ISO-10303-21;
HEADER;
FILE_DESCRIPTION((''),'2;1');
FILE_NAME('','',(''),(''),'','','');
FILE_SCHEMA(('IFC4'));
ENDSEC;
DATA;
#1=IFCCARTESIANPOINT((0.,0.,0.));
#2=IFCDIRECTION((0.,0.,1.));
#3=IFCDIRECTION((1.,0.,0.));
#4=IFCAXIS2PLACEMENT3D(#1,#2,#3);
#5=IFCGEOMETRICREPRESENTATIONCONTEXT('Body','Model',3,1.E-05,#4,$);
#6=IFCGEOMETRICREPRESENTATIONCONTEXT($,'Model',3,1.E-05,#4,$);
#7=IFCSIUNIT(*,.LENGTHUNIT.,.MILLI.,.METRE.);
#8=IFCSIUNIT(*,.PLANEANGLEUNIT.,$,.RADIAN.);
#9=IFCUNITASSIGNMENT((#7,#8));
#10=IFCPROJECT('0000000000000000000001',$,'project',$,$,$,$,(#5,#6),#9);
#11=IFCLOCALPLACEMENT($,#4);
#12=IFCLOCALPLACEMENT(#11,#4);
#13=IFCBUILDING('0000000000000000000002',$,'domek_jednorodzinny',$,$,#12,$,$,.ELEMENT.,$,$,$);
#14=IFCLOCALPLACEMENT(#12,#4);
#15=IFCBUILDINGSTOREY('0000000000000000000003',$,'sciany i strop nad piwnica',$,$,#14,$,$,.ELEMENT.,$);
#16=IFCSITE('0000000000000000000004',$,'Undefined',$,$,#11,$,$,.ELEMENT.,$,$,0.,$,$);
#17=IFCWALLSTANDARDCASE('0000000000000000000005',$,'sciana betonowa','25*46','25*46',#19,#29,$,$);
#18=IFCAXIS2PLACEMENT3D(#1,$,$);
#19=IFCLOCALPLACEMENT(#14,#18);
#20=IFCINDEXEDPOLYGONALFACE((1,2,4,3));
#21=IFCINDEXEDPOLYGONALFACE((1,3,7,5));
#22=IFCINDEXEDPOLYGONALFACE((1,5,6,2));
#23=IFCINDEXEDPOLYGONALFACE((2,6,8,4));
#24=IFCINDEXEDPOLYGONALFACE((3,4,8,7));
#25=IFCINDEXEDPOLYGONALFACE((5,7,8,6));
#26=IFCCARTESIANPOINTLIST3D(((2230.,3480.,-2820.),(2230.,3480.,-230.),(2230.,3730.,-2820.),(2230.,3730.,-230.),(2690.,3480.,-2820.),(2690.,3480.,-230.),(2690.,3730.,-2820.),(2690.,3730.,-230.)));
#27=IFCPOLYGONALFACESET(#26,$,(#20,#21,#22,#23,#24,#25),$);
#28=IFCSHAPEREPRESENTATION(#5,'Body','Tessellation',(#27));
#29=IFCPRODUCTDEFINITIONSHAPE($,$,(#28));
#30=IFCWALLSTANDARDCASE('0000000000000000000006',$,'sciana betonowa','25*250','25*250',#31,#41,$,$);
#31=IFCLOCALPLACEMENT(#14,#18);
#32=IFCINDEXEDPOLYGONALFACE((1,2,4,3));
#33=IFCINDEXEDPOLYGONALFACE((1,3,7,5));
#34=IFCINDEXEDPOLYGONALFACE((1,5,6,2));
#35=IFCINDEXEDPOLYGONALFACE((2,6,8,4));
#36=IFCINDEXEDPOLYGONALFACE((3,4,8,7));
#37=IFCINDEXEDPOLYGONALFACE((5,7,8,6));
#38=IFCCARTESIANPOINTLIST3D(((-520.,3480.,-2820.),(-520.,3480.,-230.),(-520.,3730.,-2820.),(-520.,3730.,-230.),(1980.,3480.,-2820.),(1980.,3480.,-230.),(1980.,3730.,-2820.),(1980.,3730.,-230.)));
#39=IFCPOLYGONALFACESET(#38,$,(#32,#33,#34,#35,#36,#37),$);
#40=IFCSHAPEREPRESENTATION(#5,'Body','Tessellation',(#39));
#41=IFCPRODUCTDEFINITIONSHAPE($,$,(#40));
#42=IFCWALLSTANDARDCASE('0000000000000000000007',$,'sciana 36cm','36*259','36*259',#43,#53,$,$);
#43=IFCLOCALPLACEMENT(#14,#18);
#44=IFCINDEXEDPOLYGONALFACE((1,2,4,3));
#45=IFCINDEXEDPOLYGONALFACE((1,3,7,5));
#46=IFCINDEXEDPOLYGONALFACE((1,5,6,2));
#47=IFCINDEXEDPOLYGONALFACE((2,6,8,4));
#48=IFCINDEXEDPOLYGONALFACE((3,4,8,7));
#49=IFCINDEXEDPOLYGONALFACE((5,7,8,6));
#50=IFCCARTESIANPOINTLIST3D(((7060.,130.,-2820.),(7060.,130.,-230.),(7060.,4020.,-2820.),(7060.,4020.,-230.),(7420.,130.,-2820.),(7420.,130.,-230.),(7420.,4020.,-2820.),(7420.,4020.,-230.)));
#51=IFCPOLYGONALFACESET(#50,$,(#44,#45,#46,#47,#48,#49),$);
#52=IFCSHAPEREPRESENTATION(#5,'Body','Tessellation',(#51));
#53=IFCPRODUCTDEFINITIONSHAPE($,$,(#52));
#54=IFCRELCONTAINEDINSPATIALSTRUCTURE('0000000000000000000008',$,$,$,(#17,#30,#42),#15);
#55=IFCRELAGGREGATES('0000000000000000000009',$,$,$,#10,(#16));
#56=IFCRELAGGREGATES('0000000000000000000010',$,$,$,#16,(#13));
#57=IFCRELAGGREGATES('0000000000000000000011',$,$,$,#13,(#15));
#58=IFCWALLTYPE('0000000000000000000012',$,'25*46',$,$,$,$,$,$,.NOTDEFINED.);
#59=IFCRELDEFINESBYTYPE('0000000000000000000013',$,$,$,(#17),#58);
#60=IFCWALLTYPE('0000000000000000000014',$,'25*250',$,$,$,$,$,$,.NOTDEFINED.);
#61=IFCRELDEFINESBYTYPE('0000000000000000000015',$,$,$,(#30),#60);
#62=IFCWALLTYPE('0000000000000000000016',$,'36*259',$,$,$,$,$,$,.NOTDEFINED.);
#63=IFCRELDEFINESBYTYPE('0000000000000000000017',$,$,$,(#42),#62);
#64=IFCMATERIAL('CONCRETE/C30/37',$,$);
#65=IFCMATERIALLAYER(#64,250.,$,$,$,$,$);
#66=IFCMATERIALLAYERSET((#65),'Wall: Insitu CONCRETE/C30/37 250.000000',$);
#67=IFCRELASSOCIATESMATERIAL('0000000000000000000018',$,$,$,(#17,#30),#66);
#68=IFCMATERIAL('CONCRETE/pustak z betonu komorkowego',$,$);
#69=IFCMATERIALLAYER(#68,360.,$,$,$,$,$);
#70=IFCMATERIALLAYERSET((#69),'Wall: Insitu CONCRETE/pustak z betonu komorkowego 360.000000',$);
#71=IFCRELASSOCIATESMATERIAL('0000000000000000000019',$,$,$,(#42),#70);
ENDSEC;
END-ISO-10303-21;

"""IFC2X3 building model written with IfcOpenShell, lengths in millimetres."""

from ifc_helpers import new_model, si_unit, frame, frame_2d, origin_with_axes, place, context, project, spatial, rectangle, extrude, material, layer, layer_set, layer_usage, type_object, element, save


model = new_model("IFC2X3")

# Units and contexts
model_context_1 = context("Model", 3, precision=1e-05, world=origin_with_axes(), identifier="Body")
model_context_2 = context("Model", 3, precision=1e-05, world=origin_with_axes())
ifc_project = project(units=[si_unit("LENGTHUNIT", "METRE", prefix="MILLI"), si_unit("PLANEANGLEUNIT", "RADIAN")], contexts=[model_context_1, model_context_2])

# Site, building, storey
site_placement = place(None, origin_with_axes())
site = spatial("IfcSite", under=ifc_project, at=site_placement, Name="Undefined", CompositionType="ELEMENT", RefElevation=0.0)
building_placement = place(site_placement, origin_with_axes())
building = spatial("IfcBuilding", under=site, at=building_placement, Name="domek_jednorodzinny", CompositionType="ELEMENT")
storey_placement = place(building_placement, origin_with_axes())
storey = spatial("IfcBuildingStorey", under=building, at=storey_placement, Name="sciany i strop nad piwnica", CompositionType="ELEMENT")

# Shared definitions
ifc_material_1 = material(Name="CONCRETE/C30/37")

# Shared definitions
ifc_layer_1 = layer(ifc_material_1, 250.0)
ifc_layer_set_1 = layer_set([ifc_layer_1], Name="Wall: Insitu CONCRETE/C30/37 250.000000")

# Walls
ifc_layer_usage_1 = layer_usage(ifc_layer_set_1, "AXIS2", "POSITIVE", -125.0)
wall_type_1 = type_object("IfcWallType", Name="25*46", PredefinedType="NOTDEFINED")
wall_1_placement = place(storey_placement, frame((2230.0, 3605.0, -2820.0), z_axis=(0.0, 0.0, 1.0), x_axis=(1.0, 0.0, 0.0)))
element("IfcWallStandardCase", 1, at=wall_1_placement, inside=storey, type_object=wall_type_1, material=ifc_layer_usage_1, Name="sciana betonowa", Description="25*46", ObjectType="25*46", context=model_context_1, shape_type="SweptSolid", body=[
    extrude(rectangle(XDim=460.0, YDim=250.0, at=frame_2d((0.0, 230.0), x_axis=(0.0, -1.0))), frame((0.0, 0.0, 0.0), z_axis=(0.0, 0.0, 1.0), x_axis=(0.0, -1.0, 0.0)), (0.0, 0.0, 1.0), 2590.0),
])
ifc_layer_usage_2 = layer_usage(ifc_layer_set_1, "AXIS2", "POSITIVE", -125.0)
wall_type_2 = type_object("IfcWallType", Name="25*250", PredefinedType="NOTDEFINED")
wall_2_placement = place(storey_placement, frame((-520.0, 3605.0, -2820.0), z_axis=(0.0, 0.0, 1.0), x_axis=(1.0, 0.0, 0.0)))
element("IfcWallStandardCase", 2, at=wall_2_placement, inside=storey, type_object=wall_type_2, material=ifc_layer_usage_2, Name="sciana betonowa", Description="25*250", ObjectType="25*250", context=model_context_1, shape_type="SweptSolid", body=[
    extrude(rectangle(XDim=2500.0, YDim=250.0, at=frame_2d((0.0, 1250.0), x_axis=(0.0, -1.0))), frame((0.0, 0.0, 0.0), z_axis=(0.0, 0.0, 1.0), x_axis=(0.0, -1.0, 0.0)), (0.0, 0.0, 1.0), 2590.0),
])
ifc_material_2 = material(Name="CONCRETE/pustak z betonu komorkowego")
ifc_layer_2 = layer(ifc_material_2, 360.0)
ifc_layer_set_2 = layer_set([ifc_layer_2], Name="Wall: Insitu CONCRETE/pustak z betonu komorkowego 360.000000")
ifc_layer_usage_3 = layer_usage(ifc_layer_set_2, "AXIS2", "POSITIVE", -180.0)
wall_type_3 = type_object("IfcWallType", Name="36*259", PredefinedType="NOTDEFINED")
wall_3_placement = place(storey_placement, frame((7240.0, 130.0, -2820.0), z_axis=(0.0, 0.0, 1.0), x_axis=(0.0, 1.0, 0.0)))
element("IfcWallStandardCase", 3, at=wall_3_placement, inside=storey, type_object=wall_type_3, material=ifc_layer_usage_3, Name="sciana 36cm", Description="36*259", ObjectType="36*259", context=model_context_1, shape_type="SweptSolid", body=[
    extrude(rectangle(XDim=3890.0, YDim=360.0, at=frame_2d((0.0, 1945.0), x_axis=(0.0, -1.0))), frame((0.0, 0.0, 0.0), z_axis=(0.0, 0.0, 1.0), x_axis=(0.0, -1.0, 0.0)), (0.0, 0.0, 1.0), 2590.0),
])

save(model, "model.ifc")
